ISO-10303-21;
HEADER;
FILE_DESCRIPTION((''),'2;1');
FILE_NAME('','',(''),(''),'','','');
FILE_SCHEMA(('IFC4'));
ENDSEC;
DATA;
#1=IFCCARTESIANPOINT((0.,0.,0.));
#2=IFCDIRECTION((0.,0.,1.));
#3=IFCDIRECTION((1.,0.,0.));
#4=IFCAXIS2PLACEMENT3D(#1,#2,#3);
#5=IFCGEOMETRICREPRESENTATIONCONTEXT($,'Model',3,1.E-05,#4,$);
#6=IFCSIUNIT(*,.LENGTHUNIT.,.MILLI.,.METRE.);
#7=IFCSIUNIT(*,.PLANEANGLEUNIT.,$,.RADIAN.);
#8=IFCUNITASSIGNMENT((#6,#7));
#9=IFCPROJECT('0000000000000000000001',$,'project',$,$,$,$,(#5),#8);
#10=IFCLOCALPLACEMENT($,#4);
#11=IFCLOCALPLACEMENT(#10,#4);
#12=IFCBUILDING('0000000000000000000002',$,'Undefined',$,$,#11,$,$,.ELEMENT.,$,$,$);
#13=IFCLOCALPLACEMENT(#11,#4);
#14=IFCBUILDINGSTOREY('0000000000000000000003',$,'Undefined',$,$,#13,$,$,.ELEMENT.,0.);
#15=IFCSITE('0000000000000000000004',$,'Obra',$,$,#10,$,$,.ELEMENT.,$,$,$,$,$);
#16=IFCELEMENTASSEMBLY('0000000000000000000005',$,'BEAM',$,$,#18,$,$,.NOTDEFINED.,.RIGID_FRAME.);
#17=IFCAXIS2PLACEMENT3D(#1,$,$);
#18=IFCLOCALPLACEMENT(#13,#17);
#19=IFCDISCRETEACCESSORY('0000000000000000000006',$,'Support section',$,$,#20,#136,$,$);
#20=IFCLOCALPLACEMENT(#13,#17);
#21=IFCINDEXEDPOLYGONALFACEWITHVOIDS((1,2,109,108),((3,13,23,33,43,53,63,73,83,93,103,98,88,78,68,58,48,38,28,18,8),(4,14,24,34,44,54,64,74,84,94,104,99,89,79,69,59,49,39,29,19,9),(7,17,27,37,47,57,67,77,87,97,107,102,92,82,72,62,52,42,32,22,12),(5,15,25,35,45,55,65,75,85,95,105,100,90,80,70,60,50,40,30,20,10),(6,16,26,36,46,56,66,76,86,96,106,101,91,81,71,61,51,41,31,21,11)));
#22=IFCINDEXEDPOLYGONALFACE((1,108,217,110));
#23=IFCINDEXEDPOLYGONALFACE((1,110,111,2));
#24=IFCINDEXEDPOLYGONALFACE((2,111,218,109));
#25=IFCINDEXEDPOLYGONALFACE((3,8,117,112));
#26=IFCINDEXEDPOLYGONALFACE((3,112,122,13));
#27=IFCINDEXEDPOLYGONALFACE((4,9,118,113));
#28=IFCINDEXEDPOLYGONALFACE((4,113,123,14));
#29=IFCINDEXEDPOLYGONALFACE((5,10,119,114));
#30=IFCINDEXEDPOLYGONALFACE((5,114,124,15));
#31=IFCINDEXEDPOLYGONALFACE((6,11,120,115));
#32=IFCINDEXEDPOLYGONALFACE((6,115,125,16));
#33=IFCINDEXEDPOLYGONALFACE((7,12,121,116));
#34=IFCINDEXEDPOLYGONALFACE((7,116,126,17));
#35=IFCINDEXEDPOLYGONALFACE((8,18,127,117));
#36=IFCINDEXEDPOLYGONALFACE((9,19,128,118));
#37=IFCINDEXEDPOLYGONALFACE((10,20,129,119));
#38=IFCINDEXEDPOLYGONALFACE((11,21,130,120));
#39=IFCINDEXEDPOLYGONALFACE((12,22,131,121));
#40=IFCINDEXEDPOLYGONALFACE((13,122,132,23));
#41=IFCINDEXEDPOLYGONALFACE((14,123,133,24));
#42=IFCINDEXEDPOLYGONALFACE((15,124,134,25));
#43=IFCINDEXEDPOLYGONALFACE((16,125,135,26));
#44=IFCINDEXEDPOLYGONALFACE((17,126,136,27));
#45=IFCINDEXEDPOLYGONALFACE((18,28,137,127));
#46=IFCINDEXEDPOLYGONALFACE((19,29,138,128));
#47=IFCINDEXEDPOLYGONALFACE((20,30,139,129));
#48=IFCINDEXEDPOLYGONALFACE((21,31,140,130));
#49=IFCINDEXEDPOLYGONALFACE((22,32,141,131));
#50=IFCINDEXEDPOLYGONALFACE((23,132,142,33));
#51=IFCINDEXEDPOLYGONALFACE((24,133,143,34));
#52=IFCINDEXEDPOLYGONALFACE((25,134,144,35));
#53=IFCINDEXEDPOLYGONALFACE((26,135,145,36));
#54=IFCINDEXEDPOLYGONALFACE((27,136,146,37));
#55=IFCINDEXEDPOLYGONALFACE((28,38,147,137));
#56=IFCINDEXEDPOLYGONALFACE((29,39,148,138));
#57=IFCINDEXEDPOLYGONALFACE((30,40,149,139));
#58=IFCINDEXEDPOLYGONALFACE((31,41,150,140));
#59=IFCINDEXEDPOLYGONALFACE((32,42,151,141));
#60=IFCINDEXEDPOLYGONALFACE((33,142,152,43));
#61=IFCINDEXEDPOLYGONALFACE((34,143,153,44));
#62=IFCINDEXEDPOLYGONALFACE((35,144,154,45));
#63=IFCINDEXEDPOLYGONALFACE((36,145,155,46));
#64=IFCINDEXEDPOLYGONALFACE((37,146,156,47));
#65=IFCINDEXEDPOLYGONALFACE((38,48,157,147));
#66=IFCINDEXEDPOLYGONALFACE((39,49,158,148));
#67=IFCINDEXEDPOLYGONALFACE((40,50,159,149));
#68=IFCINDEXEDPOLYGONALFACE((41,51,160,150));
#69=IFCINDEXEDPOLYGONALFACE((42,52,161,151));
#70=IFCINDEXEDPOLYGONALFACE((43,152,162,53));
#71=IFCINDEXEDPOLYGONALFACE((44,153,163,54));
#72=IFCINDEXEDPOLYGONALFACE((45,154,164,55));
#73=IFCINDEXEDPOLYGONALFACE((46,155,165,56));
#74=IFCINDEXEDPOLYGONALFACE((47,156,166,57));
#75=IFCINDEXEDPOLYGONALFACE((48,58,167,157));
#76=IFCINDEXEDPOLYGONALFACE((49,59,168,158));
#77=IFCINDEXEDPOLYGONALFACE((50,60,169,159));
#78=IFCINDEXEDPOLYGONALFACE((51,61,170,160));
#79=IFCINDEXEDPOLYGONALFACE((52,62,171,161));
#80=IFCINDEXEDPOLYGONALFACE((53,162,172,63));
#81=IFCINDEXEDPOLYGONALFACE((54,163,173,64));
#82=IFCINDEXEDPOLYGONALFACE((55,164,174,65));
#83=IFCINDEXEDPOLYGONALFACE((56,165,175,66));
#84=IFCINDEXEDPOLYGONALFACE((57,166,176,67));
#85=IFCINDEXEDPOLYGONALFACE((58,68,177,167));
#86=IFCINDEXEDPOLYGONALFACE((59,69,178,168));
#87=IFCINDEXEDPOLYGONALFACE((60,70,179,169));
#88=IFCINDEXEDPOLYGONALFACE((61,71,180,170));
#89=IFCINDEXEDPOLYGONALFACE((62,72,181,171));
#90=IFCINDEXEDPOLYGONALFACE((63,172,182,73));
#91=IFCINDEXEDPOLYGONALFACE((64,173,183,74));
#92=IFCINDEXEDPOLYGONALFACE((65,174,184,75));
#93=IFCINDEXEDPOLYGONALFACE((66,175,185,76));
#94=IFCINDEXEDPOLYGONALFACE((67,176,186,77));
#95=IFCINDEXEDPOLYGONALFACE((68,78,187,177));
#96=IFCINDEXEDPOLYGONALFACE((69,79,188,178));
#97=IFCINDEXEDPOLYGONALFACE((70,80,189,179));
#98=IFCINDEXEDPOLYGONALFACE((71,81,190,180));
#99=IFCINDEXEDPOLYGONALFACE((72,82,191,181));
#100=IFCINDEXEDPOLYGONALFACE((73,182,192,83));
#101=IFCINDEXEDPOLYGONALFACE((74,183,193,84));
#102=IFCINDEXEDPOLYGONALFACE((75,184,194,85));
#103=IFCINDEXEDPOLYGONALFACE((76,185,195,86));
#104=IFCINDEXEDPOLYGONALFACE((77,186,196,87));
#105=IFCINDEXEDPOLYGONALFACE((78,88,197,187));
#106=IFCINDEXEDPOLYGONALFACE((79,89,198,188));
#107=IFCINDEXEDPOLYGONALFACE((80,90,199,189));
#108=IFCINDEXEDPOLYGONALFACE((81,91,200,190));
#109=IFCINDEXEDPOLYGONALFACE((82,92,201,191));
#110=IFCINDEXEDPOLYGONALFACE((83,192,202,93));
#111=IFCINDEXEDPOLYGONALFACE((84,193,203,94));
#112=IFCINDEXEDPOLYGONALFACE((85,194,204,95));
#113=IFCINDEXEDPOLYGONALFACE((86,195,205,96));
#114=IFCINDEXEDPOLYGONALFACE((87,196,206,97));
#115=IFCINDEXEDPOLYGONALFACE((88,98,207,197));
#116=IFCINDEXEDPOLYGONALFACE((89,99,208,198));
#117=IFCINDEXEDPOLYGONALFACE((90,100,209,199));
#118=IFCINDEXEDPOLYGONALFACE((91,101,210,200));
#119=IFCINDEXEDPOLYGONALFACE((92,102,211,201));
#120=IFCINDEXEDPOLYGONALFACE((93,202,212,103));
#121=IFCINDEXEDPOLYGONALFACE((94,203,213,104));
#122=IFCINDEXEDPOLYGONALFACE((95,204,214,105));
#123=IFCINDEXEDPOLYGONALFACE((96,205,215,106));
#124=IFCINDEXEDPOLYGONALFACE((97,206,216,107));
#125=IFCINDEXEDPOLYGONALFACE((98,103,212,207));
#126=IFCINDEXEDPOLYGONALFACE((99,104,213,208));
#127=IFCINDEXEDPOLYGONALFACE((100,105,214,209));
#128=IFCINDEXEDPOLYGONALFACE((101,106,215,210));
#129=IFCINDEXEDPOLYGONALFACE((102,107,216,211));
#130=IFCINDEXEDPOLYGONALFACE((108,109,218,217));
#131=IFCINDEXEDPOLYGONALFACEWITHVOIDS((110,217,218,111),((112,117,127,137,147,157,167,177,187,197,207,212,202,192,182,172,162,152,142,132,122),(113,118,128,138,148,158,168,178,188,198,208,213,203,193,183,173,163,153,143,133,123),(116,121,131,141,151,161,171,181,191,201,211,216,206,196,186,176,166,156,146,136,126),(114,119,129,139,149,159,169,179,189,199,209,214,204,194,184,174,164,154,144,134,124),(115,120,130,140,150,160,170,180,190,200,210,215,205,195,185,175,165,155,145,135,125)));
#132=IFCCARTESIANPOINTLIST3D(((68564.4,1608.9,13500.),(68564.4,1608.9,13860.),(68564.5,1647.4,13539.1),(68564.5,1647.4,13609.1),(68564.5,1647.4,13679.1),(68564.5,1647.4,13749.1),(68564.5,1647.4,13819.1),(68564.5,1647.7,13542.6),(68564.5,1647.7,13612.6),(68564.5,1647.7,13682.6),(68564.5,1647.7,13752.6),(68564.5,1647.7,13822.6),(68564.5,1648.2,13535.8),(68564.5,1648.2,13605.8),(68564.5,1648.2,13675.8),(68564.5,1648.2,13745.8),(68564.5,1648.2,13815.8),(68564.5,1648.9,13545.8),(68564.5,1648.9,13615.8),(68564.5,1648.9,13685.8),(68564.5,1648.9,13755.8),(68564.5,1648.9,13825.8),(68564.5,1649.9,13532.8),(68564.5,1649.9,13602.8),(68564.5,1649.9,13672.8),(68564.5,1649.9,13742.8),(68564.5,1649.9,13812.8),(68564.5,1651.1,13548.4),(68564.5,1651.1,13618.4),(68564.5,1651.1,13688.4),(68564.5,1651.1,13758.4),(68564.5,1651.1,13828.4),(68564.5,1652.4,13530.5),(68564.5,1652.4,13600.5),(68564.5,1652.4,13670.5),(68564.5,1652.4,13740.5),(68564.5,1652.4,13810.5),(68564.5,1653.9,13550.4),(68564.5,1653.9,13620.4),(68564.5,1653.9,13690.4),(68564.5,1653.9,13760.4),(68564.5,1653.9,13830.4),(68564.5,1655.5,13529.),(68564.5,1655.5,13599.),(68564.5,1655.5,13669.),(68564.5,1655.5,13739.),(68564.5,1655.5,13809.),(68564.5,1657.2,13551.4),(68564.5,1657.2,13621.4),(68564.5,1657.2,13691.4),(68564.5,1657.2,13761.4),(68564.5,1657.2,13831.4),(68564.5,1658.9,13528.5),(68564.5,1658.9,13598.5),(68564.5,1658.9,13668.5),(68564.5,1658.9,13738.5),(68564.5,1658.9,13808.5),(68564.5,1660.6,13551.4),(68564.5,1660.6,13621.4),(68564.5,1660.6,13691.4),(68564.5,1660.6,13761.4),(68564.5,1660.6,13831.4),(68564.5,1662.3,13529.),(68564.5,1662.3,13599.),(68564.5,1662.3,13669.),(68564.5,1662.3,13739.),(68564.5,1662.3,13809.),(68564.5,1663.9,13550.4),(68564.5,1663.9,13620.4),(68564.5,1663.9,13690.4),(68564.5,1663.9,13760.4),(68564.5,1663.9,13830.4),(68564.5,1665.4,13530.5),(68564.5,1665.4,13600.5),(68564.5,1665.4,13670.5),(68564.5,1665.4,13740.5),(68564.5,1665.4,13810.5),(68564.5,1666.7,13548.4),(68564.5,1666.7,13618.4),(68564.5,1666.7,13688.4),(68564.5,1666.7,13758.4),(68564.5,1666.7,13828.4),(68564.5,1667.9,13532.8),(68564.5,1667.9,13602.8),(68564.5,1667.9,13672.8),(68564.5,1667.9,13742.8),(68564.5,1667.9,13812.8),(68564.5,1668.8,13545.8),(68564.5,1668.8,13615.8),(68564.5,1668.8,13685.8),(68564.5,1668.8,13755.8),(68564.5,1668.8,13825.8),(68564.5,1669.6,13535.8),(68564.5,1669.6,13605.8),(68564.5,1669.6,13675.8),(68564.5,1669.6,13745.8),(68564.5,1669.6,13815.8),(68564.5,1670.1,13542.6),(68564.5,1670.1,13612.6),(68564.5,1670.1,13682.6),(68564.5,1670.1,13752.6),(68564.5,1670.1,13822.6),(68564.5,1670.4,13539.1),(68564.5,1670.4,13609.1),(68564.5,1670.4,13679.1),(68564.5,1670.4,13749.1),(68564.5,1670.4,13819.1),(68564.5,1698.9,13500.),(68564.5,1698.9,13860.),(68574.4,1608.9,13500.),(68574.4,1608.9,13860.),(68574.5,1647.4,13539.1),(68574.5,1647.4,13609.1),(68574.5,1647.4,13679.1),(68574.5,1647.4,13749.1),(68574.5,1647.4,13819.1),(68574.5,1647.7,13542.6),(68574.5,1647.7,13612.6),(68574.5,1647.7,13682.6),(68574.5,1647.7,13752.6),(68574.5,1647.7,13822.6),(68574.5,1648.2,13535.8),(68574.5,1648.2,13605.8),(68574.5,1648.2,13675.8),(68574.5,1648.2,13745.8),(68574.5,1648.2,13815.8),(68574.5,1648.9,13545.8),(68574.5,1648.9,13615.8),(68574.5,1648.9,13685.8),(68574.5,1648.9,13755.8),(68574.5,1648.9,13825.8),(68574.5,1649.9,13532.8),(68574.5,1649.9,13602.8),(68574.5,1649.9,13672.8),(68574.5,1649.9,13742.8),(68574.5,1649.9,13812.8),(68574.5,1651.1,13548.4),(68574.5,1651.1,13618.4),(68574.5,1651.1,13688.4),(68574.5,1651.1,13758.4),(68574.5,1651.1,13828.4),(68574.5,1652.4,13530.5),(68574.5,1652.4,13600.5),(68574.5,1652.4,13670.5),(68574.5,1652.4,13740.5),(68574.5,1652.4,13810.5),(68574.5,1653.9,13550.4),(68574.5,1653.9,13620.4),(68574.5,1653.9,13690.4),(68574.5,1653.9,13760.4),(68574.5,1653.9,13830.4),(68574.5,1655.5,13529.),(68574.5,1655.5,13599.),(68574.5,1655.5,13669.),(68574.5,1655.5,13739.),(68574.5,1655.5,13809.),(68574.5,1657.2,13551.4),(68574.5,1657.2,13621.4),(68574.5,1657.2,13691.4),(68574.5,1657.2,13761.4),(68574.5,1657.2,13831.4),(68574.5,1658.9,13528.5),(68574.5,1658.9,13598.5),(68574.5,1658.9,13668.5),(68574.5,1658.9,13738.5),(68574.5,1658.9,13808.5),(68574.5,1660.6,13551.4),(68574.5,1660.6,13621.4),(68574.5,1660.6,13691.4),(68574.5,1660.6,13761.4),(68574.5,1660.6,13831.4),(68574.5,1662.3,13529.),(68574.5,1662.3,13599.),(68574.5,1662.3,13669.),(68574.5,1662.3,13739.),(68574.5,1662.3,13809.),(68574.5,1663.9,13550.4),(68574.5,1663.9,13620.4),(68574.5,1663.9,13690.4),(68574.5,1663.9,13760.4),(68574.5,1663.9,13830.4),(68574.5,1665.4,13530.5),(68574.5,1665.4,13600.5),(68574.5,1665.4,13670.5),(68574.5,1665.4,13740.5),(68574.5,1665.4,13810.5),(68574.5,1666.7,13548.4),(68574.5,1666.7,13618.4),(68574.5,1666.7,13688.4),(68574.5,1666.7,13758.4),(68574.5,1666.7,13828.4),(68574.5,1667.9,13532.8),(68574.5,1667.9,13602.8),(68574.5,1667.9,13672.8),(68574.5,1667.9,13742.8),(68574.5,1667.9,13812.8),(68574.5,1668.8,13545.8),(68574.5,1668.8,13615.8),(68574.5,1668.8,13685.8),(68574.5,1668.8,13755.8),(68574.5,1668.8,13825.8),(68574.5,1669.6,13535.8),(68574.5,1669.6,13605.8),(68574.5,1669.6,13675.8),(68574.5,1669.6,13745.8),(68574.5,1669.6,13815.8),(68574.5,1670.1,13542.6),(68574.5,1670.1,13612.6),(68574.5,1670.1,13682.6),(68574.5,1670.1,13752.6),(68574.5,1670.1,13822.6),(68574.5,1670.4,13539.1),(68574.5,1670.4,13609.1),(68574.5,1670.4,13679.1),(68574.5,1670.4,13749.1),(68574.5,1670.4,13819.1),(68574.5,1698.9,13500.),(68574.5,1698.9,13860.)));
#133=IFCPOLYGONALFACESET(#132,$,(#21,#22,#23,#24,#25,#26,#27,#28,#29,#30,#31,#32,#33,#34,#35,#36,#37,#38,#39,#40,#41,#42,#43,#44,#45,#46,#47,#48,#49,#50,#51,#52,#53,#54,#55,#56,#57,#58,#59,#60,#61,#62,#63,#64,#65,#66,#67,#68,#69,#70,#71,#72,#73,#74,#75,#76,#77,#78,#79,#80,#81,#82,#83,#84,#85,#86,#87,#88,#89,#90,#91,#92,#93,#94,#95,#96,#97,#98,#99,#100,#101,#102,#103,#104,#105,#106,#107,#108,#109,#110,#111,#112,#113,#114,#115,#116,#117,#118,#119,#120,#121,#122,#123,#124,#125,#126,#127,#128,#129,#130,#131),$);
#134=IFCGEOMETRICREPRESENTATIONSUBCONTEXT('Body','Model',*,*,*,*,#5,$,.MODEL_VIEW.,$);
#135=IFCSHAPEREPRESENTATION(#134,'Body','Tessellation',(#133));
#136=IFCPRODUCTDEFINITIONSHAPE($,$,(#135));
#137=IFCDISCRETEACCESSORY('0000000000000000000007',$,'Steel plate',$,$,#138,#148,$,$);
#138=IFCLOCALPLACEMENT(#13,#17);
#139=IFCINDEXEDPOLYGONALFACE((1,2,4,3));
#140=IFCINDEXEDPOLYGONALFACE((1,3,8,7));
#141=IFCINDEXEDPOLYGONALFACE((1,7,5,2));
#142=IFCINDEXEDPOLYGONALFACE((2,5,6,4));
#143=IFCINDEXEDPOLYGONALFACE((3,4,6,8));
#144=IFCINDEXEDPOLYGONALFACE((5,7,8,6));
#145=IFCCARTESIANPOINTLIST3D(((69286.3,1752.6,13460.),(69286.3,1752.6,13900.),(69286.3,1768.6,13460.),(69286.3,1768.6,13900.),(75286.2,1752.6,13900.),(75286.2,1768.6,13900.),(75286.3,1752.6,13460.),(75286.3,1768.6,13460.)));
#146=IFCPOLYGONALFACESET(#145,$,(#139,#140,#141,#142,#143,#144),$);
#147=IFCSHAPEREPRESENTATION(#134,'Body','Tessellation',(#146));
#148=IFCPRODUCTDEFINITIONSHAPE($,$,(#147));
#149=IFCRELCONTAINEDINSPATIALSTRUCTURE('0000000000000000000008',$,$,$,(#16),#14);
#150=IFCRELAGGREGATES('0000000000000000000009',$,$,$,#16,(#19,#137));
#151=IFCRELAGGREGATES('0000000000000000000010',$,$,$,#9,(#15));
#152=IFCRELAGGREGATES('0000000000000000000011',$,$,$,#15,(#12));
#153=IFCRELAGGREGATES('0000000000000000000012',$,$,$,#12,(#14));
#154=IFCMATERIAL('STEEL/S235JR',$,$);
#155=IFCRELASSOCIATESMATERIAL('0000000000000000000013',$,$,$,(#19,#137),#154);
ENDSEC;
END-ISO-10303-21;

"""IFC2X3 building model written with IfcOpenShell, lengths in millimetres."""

from ifc_helpers import new_model, si_unit, frame, origin_with_axes, origin_2d_with_axis, place, context, subcontext, project, spatial, polyline, rectangle, circle, outline, extrude, source, transform, mapped, material, element, aggregate, save


model = new_model("IFC2X3")

# Units and contexts
model_context = context("Model", 3, precision=1e-05, world=origin_with_axes())
body_context = subcontext(model_context, "Body", "Model", "MODEL_VIEW")
ifc_project = project(units=[si_unit("LENGTHUNIT", "METRE", prefix="MILLI"), si_unit("PLANEANGLEUNIT", "RADIAN")], contexts=[model_context])

# Site, building, storey
site_placement = place(None, origin_with_axes())
site = spatial("IfcSite", under=ifc_project, at=site_placement, Name="Obra", CompositionType="ELEMENT")
building_placement = place(site_placement, origin_with_axes())
building = spatial("IfcBuilding", under=site, at=building_placement, Name="Undefined", CompositionType="ELEMENT")
storey_placement = place(building_placement, origin_with_axes())
storey = spatial("IfcBuildingStorey", under=building, at=storey_placement, Name="Undefined", CompositionType="ELEMENT", Elevation=0.0)

# Shared definitions
ifc_material_1 = material(Name="STEEL/S235JR")

# Element assembly
assembly_1_placement = place(storey_placement, origin_with_axes())
assembly_1 = element("IfcElementAssembly", 1, at=assembly_1_placement, inside=storey, Name="BEAM", AssemblyPlace="NOTDEFINED", PredefinedType="RIGID_FRAME")

# Discrete accessory, opening
discrete_accessory_1_placement = place(assembly_1_placement, frame((68569.5, 1653.9, 13500.0), z_axis=(0.0, 0.0, 1.0), x_axis=(-0.000708, -1.0, 0.0)))
discrete_accessory_1 = element("IfcDiscreteAccessory", 2, at=discrete_accessory_1_placement, material=ifc_material_1, Name="Support section", context=body_context, shape_type="SweptSolid", body=[
    extrude(rectangle(XDim=10.0, YDim=90.0, at=origin_2d_with_axis()), frame((0.0, 0.0, 360.0), z_axis=(0.0, 0.0, -1.0), x_axis=(0.0, 1.0, 0.0)), (0.0, 0.0, 1.0), 360.0),
])
shared_shape_1 = source(origin_with_axes(), body_context, "Body", "SweptSolid", [
    extrude(circle(Radius=11.5, at=origin_2d_with_axis()), frame((0.0, -15.8, 0.0), z_axis=(0.0, 1.0, 0.0), x_axis=(1.0, 0.0, 0.0)), (0.0, 0.0, 1.0), 10.2),
])
opening_1_placement = place(assembly_1_placement, frame((68558.7, 1618.9, 13900.0), z_axis=(0.000708, 1.0, 0.0), x_axis=(0.0, 0.0, -1.0)))
element("IfcOpeningElement", 3, at=opening_1_placement, cuts=discrete_accessory_1, ObjectType="Opening", context=body_context, shape_type="MappedRepresentation", body=[
    mapped(shared_shape_1, transform((80.0, 0.0, 40.0))),
    mapped(shared_shape_1, transform((150.0, 0.0, 40.0))),
    mapped(shared_shape_1, transform((220.0, 0.0, 40.0))),
    mapped(shared_shape_1, transform((290.0, 0.0, 40.0))),
    mapped(shared_shape_1, transform((360.0, 0.0, 40.0))),
])

# Discrete accessory
discrete_accessory_2_placement = place(assembly_1_placement, frame((69286.3, 1760.6, 13900.0), z_axis=(0.0, -1.0, 0.0), x_axis=(0.0, 0.0, -1.0)))
discrete_accessory_2 = element("IfcDiscreteAccessory", 4, at=discrete_accessory_2_placement, material=ifc_material_1, Name="Steel plate", context=body_context, shape_type="SweptSolid", body=[
    extrude(outline(polyline([(0.0, 0.0), (440.0, 0.0), (440.0, 6000.0), (0.0, 5999.9), (0.0, 0.0)])), frame((0.0, 0.0, -8.0), z_axis=(0.0, 0.0, 1.0), x_axis=(1.0, 0.0, 0.0)), (0.0, 0.0, 1.0), 16.0),
])
aggregate(assembly_1, [discrete_accessory_1, discrete_accessory_2])

save(model, "model.ifc")
